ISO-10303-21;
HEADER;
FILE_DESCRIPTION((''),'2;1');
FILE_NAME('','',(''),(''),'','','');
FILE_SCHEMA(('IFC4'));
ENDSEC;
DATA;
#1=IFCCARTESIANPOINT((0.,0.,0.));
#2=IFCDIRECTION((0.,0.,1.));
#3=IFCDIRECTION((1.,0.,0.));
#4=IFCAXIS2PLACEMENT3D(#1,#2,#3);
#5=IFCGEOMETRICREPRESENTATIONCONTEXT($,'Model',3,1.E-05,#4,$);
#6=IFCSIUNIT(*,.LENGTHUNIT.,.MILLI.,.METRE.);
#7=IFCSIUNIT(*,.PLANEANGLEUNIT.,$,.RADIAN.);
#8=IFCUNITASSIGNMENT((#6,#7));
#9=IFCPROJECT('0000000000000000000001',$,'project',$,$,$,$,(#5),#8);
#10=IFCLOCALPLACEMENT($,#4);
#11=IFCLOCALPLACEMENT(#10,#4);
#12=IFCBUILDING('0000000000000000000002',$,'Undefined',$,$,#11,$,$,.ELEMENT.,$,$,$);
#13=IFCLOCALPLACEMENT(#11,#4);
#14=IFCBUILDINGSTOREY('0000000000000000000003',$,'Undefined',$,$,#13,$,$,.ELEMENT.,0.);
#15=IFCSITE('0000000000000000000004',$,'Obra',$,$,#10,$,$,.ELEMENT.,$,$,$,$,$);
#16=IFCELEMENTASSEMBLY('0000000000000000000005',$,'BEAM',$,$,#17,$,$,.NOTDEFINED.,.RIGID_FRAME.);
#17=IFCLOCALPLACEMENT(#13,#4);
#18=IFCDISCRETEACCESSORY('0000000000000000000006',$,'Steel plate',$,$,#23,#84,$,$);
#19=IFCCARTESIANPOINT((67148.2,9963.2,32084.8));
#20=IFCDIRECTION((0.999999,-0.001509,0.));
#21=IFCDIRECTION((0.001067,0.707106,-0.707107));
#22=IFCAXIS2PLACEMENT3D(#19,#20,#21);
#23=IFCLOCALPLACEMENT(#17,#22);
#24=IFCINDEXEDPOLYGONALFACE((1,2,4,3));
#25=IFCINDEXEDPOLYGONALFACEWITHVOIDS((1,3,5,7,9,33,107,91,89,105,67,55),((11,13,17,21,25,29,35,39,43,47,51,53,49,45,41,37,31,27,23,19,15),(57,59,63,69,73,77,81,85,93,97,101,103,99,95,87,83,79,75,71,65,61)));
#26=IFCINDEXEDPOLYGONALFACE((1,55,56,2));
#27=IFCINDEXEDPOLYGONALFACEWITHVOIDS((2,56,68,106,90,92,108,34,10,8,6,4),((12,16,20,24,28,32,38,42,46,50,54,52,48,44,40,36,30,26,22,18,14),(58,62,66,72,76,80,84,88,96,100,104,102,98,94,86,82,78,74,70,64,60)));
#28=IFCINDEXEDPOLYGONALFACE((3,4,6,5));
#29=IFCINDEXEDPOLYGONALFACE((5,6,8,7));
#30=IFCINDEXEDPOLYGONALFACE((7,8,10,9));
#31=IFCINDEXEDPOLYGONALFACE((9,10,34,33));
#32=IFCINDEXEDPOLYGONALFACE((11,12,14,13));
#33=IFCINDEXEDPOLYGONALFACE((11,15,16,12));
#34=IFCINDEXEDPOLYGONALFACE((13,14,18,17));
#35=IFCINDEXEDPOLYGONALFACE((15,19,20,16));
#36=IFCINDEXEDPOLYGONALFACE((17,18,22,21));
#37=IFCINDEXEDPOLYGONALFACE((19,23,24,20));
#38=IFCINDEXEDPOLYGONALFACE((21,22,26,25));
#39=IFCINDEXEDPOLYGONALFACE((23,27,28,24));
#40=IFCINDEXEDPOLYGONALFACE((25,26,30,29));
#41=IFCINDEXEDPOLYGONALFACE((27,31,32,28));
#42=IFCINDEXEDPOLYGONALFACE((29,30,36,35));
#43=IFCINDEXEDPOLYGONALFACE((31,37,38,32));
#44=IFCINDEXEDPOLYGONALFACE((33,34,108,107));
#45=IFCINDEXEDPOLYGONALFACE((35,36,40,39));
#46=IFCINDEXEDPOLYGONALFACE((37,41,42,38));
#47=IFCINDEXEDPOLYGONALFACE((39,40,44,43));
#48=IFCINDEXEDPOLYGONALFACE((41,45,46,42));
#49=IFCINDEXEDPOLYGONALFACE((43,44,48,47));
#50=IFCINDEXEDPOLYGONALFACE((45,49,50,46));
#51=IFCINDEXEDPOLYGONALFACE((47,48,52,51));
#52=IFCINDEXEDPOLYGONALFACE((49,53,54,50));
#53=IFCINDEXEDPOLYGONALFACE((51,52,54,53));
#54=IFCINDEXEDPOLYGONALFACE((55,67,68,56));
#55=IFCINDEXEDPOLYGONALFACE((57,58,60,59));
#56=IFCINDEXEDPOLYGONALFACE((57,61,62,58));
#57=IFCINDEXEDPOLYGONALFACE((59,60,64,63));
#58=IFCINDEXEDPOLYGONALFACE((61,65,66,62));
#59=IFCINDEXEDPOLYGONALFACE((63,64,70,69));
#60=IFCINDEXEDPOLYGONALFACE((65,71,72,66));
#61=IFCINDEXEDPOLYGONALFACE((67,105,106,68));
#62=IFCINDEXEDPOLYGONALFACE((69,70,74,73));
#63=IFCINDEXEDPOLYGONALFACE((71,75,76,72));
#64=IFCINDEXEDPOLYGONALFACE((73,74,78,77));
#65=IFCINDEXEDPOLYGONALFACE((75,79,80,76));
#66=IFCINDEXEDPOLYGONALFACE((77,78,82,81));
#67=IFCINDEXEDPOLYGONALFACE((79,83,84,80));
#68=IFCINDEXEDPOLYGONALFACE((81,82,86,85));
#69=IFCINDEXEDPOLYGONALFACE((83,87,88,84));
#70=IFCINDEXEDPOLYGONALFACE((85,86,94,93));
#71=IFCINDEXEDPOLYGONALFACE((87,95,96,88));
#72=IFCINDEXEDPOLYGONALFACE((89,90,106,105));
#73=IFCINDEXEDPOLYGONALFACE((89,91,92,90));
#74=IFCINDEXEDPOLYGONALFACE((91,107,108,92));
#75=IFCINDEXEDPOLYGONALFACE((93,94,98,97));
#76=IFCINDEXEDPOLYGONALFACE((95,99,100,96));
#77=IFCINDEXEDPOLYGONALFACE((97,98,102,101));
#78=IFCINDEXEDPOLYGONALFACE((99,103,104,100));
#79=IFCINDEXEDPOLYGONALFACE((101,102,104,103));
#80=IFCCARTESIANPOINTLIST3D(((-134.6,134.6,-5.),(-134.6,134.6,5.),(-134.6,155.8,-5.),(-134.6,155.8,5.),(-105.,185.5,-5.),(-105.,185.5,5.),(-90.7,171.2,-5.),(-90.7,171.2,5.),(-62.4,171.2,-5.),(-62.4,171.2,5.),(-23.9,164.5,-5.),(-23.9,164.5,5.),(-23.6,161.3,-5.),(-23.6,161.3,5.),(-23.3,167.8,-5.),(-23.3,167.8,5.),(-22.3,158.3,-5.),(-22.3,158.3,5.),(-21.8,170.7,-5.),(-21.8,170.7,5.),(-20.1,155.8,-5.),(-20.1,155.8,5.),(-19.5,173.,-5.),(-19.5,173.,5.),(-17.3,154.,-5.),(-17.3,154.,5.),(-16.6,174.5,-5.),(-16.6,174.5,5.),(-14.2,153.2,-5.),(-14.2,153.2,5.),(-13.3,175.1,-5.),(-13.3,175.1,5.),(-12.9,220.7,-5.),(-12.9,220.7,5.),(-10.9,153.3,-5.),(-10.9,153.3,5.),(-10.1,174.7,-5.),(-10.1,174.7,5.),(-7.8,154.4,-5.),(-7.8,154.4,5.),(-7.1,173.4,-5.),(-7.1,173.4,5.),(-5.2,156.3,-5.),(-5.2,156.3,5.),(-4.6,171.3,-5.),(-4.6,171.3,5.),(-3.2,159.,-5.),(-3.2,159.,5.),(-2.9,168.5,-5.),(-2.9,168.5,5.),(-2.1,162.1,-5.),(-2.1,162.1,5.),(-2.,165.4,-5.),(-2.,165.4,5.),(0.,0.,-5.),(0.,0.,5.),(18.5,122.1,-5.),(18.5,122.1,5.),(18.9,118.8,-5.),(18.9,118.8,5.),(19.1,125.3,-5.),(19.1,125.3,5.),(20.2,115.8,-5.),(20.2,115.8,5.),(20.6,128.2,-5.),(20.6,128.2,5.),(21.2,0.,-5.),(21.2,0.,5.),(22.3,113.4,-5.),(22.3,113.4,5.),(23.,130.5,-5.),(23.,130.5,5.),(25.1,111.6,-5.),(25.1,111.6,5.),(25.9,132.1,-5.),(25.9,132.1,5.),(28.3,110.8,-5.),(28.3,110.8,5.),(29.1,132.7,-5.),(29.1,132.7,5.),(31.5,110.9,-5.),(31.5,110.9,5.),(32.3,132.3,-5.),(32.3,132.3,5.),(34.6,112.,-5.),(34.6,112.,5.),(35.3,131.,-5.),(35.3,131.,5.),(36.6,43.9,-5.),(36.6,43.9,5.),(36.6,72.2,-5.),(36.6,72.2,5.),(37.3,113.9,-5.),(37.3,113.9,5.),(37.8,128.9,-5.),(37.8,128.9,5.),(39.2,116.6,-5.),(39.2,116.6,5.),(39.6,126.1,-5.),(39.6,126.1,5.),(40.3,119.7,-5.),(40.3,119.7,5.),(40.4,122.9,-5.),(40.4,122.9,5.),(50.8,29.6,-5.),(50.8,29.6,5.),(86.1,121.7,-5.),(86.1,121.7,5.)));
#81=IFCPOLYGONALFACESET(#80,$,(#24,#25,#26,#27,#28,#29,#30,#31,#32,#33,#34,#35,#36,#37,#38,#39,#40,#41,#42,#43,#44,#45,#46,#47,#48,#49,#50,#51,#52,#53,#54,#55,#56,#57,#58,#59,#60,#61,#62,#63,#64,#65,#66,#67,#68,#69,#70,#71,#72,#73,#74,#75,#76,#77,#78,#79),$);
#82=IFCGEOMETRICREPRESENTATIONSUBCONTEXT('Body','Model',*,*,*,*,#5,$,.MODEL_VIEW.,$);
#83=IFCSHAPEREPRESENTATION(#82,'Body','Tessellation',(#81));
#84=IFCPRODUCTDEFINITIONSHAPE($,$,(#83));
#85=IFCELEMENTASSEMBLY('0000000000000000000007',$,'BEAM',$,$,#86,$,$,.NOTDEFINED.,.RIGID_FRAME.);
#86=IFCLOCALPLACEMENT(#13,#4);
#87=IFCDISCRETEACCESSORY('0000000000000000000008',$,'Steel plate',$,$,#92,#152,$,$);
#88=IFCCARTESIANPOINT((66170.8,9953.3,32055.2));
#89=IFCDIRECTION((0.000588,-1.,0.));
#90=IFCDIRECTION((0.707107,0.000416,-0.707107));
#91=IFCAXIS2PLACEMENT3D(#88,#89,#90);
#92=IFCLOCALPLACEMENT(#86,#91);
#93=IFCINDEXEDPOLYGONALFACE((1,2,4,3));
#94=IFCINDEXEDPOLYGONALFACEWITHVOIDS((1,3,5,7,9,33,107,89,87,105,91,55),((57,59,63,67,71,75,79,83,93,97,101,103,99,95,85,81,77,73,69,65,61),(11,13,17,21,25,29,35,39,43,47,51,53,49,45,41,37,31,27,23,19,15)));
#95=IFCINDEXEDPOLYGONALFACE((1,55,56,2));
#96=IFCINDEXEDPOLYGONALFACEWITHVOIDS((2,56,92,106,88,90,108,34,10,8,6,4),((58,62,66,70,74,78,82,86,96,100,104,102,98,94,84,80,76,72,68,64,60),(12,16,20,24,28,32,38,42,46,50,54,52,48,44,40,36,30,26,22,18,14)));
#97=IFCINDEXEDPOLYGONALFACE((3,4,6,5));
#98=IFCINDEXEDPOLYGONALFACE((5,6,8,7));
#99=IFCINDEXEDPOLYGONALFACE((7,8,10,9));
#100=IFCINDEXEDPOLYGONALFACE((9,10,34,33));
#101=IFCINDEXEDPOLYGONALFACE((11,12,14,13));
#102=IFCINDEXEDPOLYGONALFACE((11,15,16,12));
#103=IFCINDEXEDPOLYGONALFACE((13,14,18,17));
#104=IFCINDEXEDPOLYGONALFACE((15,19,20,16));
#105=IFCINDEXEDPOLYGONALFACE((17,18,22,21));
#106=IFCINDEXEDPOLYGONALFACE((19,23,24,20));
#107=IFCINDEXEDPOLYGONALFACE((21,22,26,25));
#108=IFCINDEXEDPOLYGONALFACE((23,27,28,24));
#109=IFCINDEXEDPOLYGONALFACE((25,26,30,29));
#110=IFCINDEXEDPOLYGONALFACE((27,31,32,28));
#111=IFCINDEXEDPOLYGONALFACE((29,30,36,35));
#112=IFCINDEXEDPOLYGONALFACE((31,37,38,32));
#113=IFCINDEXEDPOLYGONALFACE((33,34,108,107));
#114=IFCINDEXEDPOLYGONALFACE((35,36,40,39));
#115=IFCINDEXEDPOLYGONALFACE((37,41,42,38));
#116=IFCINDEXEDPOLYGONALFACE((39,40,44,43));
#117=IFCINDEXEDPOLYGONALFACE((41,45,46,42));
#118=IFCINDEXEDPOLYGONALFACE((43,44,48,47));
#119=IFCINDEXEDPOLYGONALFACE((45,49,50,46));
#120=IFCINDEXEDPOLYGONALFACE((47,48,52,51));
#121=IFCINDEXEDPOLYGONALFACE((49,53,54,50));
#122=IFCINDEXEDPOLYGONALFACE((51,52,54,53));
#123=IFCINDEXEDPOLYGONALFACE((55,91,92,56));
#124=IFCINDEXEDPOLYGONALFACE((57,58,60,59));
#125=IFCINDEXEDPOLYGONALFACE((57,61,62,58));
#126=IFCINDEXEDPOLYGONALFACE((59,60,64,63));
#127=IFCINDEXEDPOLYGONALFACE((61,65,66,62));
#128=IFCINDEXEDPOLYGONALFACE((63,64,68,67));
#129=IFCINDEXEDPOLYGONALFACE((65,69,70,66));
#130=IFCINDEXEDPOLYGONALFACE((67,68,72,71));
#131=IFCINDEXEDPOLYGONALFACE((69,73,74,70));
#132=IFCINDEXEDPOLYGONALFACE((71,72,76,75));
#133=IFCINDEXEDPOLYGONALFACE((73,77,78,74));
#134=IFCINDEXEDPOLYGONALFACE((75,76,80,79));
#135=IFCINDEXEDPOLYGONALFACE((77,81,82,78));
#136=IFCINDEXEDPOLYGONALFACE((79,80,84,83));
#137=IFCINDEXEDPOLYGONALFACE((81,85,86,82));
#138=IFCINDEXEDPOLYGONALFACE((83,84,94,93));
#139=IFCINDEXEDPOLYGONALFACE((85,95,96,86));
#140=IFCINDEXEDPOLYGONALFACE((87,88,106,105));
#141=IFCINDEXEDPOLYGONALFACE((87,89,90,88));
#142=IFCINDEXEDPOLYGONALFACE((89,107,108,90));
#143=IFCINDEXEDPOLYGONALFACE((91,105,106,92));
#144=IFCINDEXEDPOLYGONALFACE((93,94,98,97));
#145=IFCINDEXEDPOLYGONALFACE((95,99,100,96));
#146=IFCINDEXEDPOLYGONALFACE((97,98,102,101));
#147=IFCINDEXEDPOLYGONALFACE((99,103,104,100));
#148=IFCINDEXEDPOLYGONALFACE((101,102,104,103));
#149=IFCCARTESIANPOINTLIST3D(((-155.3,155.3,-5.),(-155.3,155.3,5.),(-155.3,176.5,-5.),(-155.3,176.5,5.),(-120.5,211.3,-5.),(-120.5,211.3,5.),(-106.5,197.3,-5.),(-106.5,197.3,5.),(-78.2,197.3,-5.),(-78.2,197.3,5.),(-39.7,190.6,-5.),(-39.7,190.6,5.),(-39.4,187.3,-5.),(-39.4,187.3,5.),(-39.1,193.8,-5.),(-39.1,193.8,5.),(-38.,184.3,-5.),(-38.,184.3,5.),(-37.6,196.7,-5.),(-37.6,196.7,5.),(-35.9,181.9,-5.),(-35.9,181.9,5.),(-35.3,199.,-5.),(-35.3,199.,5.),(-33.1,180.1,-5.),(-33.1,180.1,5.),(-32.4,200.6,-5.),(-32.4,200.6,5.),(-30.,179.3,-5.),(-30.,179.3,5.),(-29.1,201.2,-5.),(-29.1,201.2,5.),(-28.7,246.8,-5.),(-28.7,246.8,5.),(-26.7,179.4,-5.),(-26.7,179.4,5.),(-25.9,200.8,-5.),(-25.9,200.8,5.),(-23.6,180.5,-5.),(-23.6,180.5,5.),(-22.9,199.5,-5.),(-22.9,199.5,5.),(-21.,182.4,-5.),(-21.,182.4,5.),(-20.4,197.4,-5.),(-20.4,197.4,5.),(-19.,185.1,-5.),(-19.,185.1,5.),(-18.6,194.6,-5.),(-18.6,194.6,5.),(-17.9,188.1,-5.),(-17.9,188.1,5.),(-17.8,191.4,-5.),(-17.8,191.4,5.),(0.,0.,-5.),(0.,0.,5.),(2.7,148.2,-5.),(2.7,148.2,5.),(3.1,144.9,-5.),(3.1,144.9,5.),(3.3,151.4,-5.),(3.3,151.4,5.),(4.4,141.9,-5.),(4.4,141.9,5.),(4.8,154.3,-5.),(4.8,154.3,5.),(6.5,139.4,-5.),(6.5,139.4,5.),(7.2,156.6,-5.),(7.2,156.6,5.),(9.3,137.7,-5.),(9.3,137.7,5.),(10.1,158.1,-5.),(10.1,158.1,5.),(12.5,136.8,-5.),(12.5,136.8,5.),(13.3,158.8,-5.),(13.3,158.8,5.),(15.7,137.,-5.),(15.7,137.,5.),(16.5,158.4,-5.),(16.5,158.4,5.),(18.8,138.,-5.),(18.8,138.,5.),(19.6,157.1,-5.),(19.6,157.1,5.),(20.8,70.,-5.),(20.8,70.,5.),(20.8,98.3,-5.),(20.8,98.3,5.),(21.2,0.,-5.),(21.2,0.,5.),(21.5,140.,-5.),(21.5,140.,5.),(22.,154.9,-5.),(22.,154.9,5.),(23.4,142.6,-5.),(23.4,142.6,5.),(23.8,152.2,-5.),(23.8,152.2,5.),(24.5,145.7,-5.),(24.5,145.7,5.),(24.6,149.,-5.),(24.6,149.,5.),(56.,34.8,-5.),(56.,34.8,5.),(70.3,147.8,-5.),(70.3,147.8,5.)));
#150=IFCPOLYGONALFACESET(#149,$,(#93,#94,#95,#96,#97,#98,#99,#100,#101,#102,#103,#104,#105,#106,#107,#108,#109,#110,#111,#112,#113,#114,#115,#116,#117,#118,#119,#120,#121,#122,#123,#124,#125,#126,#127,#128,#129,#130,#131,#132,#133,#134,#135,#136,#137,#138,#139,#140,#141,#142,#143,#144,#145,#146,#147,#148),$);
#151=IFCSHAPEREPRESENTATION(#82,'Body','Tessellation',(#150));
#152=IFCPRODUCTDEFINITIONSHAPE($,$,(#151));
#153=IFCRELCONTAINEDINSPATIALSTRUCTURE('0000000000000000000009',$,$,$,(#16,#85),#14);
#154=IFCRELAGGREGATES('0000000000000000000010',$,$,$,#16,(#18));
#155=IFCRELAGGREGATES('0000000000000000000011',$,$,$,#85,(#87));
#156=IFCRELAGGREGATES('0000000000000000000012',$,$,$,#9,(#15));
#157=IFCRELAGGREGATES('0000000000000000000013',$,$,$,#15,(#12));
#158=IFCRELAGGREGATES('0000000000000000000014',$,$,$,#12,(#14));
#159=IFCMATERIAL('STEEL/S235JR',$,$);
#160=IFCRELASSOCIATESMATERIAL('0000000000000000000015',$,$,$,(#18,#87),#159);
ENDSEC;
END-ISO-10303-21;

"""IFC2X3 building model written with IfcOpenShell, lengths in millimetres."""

from ifc_helpers import new_model, si_unit, frame, origin_with_axes, origin_2d_with_axis, place, context, subcontext, project, spatial, polyline, circle, outline, extrude, source, transform, mapped, material, element, aggregate, save


model = new_model("IFC2X3")

# Units and contexts
model_context = context("Model", 3, precision=1e-05, world=origin_with_axes())
body_context = subcontext(model_context, "Body", "Model", "MODEL_VIEW")
ifc_project = project(units=[si_unit("LENGTHUNIT", "METRE", prefix="MILLI"), si_unit("PLANEANGLEUNIT", "RADIAN")], contexts=[model_context])

# Site, building, storey
site_placement = place(None, origin_with_axes())
site = spatial("IfcSite", under=ifc_project, at=site_placement, Name="Obra", CompositionType="ELEMENT")
building_placement = place(site_placement, origin_with_axes())
building = spatial("IfcBuilding", under=site, at=building_placement, Name="Undefined", CompositionType="ELEMENT")
storey_placement = place(building_placement, origin_with_axes())
storey = spatial("IfcBuildingStorey", under=building, at=storey_placement, Name="Undefined", CompositionType="ELEMENT", Elevation=0.0)

# Element assembly
assembly_1_placement = place(storey_placement, origin_with_axes())
assembly_1 = element("IfcElementAssembly", 1, at=assembly_1_placement, inside=storey, Name="BEAM", AssemblyPlace="NOTDEFINED", PredefinedType="RIGID_FRAME")
ifc_material_1 = material(Name="STEEL/S235JR")

# Discrete accessory, opening
discrete_accessory_1_placement = place(assembly_1_placement, frame((67148.2, 9963.2, 32084.8), z_axis=(0.999999, -0.001509, 0.0), x_axis=(0.001067, 0.707106, -0.707107)))
discrete_accessory_1 = element("IfcDiscreteAccessory", 2, at=discrete_accessory_1_placement, material=ifc_material_1, Name="Steel plate", context=body_context, shape_type="SweptSolid", body=[
    extrude(outline(polyline([(0.0, 0.0), (21.2, 0.0), (50.8, 29.6), (36.6, 43.9), (36.6, 72.2), (86.1, 121.7), (-12.9, 220.7), (-62.4, 171.2), (-90.7, 171.2), (-105.0, 185.5), (-134.6, 155.8), (-134.6, 134.6), (0.0, 0.0)])), frame((0.0, 0.0, -5.0), z_axis=(0.0, 0.0, 1.0), x_axis=(1.0, 0.0, 0.0)), (0.0, 0.0, 1.0), 10.0),
])
shared_shape_1 = source(origin_with_axes(), body_context, "Body", "SweptSolid", [
    extrude(circle(Radius=11.0, at=origin_2d_with_axis()), frame((0.0, -13.1, 0.0), z_axis=(0.0, 1.0, 0.0), x_axis=(1.0, 0.0, 0.0)), (0.0, 0.0, 1.0), 10.2),
])
opening_1_placement = place(assembly_1_placement, frame((67140.3, 10030.1, 32250.0), z_axis=(0.001509, 0.999999, 0.0), x_axis=(0.0, 0.0, -1.0)))
element("IfcOpeningElement", 3, at=opening_1_placement, cuts=discrete_accessory_1, ObjectType="Opening", context=body_context, shape_type="MappedRepresentation", body=[
    mapped(shared_shape_1, transform((40.0, 0.0, 40.0))),
    mapped(shared_shape_1, transform((100.0, 0.0, 40.0))),
])
aggregate(assembly_1, [discrete_accessory_1])

# Element assembly, discrete accessory, opening
assembly_2_placement = place(storey_placement, origin_with_axes())
assembly_2 = element("IfcElementAssembly", 4, at=assembly_2_placement, inside=storey, Name="BEAM", AssemblyPlace="NOTDEFINED", PredefinedType="RIGID_FRAME")
discrete_accessory_2_placement = place(assembly_2_placement, frame((66170.8, 9953.3, 32055.2), z_axis=(0.000588, -1.0, 0.0), x_axis=(0.707107, 0.000416, -0.707107)))
discrete_accessory_2 = element("IfcDiscreteAccessory", 5, at=discrete_accessory_2_placement, material=ifc_material_1, Name="Steel plate", context=body_context, shape_type="SweptSolid", body=[
    extrude(outline(polyline([(0.0, 0.0), (21.2, 0.0), (56.0, 34.8), (20.8, 70.0), (20.8, 98.3), (70.3, 147.8), (-28.7, 246.8), (-78.2, 197.3), (-106.5, 197.3), (-120.5, 211.3), (-155.3, 176.5), (-155.3, 155.3), (0.0, 0.0)])), frame((0.0, 0.0, -5.0), z_axis=(0.0, 0.0, 1.0), x_axis=(1.0, 0.0, 0.0)), (0.0, 0.0, 1.0), 10.0),
])
shared_shape_2 = source(origin_with_axes(), body_context, "Body", "SweptSolid", [
    extrude(circle(Radius=11.0, at=origin_2d_with_axis()), frame((0.0, -13.4, 0.0), z_axis=(0.0, 1.0, 0.0), x_axis=(1.0, 0.0, 0.0)), (0.0, 0.0, 1.0), 10.2),
])
opening_2_placement = place(assembly_2_placement, frame((66244.9, 9961.6, 32250.0), z_axis=(1.0, 0.000588, 0.0), x_axis=(0.0, 0.0, -1.0)))
element("IfcOpeningElement", 6, at=opening_2_placement, cuts=discrete_accessory_2, ObjectType="Opening", context=body_context, shape_type="MappedRepresentation", body=[
    mapped(shared_shape_2, transform((40.0, 0.0, 40.0))),
    mapped(shared_shape_2, transform((100.0, 0.0, 40.0))),
])
aggregate(assembly_2, [discrete_accessory_2])

save(model, "model.ifc")
